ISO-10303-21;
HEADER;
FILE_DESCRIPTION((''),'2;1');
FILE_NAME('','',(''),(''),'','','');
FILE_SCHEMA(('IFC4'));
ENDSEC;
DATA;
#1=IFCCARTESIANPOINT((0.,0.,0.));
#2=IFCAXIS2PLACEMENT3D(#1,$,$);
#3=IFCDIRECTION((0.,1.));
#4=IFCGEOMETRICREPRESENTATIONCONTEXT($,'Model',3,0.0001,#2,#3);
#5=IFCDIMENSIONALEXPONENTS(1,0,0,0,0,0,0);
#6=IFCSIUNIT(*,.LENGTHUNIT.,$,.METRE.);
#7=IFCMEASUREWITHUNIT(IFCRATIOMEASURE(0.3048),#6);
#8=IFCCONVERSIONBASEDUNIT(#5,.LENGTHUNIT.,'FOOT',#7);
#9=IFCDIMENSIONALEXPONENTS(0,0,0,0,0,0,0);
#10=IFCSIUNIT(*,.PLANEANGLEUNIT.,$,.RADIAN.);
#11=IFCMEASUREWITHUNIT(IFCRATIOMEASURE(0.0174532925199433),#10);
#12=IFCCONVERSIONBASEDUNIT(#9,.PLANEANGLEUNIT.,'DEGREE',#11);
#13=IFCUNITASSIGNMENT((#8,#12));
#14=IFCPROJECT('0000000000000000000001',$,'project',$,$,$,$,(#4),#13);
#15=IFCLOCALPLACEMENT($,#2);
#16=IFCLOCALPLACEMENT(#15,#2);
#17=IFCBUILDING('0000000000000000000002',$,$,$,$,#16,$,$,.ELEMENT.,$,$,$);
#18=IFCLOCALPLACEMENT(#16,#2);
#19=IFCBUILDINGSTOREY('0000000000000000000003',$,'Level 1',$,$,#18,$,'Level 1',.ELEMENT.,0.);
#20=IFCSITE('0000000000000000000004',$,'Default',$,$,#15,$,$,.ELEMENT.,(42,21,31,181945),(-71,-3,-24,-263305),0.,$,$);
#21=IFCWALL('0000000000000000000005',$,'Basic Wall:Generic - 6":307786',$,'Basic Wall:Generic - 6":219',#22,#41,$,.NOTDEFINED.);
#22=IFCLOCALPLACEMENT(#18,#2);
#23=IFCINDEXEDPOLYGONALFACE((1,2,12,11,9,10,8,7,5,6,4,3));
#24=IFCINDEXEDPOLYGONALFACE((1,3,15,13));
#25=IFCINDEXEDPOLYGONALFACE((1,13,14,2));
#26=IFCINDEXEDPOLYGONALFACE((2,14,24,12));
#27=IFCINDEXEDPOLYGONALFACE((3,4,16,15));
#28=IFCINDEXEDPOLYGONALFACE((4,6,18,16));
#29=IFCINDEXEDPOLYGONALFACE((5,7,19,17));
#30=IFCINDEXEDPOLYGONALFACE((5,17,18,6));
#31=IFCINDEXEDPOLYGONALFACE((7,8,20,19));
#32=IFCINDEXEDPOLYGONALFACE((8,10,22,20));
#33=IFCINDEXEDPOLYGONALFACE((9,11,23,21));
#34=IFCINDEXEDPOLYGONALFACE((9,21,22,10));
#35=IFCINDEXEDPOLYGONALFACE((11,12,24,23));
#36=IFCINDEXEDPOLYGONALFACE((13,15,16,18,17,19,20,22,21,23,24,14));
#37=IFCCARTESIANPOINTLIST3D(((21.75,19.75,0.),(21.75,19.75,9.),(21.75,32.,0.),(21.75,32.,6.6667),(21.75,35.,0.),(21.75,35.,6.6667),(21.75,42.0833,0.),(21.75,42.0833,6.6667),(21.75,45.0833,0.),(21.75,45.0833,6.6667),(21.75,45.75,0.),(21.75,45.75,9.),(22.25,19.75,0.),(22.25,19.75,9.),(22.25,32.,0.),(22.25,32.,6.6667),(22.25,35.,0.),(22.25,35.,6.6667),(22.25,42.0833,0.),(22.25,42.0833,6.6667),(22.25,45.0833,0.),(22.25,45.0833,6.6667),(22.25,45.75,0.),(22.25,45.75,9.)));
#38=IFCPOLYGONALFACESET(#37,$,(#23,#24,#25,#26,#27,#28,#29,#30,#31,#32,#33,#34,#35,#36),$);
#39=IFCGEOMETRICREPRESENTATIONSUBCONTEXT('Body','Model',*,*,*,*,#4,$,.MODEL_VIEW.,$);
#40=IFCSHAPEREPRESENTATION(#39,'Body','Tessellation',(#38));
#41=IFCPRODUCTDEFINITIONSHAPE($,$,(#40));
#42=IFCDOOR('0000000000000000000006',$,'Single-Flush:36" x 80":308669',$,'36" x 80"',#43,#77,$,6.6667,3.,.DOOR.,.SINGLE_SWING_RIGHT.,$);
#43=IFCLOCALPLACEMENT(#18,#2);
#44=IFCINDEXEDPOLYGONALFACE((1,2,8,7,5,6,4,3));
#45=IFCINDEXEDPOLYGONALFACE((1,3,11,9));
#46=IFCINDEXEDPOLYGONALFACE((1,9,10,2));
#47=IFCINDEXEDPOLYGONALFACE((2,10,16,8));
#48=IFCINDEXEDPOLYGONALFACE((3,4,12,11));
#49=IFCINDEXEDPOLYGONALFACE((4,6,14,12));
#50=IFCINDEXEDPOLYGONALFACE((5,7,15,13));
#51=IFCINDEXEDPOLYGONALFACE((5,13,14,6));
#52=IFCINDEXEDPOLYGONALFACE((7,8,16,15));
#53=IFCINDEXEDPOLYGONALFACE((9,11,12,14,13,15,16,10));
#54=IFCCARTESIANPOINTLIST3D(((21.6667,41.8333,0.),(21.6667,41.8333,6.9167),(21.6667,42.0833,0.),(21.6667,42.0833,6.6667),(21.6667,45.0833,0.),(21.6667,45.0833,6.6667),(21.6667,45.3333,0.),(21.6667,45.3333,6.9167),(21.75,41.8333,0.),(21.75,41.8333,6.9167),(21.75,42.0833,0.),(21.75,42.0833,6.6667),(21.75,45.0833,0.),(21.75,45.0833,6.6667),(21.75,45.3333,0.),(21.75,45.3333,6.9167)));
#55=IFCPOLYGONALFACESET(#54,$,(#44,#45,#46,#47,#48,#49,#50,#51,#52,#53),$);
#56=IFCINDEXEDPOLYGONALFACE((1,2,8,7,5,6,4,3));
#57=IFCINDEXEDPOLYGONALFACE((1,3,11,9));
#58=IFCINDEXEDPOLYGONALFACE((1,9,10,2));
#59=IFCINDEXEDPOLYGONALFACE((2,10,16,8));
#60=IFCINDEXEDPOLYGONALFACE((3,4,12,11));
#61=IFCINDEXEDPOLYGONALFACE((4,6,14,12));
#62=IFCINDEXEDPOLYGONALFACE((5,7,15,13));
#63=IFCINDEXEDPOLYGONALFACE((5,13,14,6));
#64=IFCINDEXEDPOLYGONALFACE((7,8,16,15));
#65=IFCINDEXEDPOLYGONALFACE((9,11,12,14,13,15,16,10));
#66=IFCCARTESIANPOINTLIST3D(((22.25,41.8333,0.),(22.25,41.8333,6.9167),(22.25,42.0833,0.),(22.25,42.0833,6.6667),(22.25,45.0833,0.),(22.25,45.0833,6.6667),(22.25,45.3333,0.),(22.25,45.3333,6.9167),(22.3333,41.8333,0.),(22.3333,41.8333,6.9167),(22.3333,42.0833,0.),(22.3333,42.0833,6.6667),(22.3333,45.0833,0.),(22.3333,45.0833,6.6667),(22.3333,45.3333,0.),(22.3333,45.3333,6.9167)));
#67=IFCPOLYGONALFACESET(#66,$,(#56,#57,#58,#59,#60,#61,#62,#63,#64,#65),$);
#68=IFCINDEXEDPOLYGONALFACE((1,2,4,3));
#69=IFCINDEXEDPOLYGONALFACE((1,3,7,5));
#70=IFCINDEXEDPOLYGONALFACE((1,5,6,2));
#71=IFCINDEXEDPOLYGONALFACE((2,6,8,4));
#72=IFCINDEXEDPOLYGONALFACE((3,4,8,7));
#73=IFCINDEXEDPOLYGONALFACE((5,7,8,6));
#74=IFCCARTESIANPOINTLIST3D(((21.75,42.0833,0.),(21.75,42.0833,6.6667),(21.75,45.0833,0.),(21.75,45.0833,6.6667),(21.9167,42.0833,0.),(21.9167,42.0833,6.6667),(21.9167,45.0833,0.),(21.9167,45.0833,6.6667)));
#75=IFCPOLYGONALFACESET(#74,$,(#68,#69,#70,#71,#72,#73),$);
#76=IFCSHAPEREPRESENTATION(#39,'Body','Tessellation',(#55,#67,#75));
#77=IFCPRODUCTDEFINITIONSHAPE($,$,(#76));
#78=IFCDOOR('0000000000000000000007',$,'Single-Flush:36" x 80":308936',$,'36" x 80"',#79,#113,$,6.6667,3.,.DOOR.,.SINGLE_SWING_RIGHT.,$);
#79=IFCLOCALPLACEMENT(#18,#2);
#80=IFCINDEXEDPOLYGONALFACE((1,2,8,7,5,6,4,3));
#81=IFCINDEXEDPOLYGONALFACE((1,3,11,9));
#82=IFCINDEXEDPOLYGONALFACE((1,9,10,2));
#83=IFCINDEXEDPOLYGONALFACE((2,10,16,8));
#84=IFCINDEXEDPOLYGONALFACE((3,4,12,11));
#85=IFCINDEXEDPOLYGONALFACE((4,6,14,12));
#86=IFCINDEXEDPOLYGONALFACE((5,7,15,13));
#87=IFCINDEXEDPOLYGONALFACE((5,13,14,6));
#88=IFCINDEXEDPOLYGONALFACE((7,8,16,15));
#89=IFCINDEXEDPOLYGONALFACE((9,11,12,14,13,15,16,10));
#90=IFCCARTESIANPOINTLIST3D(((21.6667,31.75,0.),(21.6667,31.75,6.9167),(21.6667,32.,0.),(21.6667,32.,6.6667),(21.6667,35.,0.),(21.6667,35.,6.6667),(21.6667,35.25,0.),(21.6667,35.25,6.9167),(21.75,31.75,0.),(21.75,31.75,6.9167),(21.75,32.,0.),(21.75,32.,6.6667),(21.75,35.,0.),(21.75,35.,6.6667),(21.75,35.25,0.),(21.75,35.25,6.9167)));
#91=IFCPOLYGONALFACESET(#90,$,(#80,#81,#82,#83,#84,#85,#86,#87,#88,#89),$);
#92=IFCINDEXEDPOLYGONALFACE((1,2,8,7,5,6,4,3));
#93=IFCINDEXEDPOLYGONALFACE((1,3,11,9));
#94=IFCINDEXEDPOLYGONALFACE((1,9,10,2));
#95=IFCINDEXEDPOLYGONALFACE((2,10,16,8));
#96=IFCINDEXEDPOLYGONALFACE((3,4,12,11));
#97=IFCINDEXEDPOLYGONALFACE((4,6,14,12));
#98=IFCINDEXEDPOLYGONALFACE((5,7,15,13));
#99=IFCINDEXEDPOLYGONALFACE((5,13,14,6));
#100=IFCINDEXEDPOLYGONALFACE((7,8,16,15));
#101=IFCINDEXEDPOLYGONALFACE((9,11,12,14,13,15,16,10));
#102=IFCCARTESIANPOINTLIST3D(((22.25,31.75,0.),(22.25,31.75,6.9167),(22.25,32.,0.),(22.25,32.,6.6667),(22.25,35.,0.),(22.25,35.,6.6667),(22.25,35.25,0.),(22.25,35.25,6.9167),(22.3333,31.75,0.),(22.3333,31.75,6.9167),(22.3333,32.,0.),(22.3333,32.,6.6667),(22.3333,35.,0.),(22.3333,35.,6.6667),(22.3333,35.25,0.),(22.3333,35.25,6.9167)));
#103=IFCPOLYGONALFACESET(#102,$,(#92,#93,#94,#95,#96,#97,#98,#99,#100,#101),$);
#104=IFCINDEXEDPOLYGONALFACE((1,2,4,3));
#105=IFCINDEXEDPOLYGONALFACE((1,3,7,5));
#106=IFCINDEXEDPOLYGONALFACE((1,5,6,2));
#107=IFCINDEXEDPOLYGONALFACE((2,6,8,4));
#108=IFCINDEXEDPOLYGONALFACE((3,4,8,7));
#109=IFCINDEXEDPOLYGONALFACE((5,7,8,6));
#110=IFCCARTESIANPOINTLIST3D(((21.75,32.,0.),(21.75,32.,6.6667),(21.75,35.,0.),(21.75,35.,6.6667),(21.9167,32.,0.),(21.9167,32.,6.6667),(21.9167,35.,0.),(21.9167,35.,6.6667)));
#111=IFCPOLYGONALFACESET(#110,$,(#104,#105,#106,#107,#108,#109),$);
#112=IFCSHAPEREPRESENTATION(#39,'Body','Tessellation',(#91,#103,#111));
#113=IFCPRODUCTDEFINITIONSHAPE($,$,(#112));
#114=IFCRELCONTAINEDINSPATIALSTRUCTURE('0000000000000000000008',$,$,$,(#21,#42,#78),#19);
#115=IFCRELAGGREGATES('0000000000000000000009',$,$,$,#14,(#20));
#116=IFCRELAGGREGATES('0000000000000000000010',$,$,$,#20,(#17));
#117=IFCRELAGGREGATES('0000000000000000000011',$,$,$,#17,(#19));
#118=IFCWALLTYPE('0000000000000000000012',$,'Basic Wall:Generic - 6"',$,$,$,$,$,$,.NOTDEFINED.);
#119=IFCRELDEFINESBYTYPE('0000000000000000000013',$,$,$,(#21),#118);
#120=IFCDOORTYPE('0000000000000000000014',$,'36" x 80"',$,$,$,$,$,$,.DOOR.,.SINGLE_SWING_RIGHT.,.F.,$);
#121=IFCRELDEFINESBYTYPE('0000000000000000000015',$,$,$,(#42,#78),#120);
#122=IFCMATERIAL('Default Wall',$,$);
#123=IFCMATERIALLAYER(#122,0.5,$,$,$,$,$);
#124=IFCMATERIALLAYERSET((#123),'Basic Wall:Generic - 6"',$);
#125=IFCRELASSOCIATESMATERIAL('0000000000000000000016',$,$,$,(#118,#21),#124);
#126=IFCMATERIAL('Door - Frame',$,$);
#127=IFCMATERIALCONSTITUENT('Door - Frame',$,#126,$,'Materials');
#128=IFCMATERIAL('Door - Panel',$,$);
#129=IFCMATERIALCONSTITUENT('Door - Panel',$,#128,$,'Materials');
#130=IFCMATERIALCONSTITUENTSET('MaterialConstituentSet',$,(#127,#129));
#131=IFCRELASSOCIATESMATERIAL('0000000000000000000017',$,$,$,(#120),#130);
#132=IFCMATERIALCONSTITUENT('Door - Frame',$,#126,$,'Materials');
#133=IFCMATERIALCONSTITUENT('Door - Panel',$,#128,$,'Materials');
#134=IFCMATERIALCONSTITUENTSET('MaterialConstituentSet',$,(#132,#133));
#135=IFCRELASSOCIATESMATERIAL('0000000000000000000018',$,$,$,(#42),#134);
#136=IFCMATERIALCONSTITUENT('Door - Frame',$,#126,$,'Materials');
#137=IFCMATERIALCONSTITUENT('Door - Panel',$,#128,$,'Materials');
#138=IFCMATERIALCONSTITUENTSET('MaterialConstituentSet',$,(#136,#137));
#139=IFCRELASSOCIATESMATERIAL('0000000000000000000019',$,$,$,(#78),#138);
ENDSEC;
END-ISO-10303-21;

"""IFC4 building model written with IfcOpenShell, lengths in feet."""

from ifc_helpers import new_model, entity, si_unit, converted_unit, direction, frame, frame_2d, origin, origin_2d_with_axis, place, context, subcontext, project, spatial, polyline, rectangle, outline, extrude, clip, bounded_halfspace, source, transform, mapped, material, layer, layer_set, layer_usage, constituent, constituent_set, type_object, type_shapes, element, fill, save


model = new_model("IFC4")

# Units and contexts
model_context = context("Model", 3, precision=0.0001, world=origin(), true_north=direction((0.0, 1.0)))
body_context = subcontext(model_context, "Body", "Model", "MODEL_VIEW")
ifc_project = project(units=[converted_unit("LENGTHUNIT", "FOOT", entity("IfcRatioMeasure", 0.3048), si_unit("LENGTHUNIT", "METRE"), dimensions=[1, 0, 0, 0, 0, 0, 0]), converted_unit("PLANEANGLEUNIT", "DEGREE", entity("IfcRatioMeasure", 0.0174532925199433), si_unit("PLANEANGLEUNIT", "RADIAN"), dimensions=[0, 0, 0, 0, 0, 0, 0])], contexts=[model_context])

# Site, building, storey
site_placement = place(None, origin())
site = spatial("IfcSite", under=ifc_project, at=site_placement, Name="Default", CompositionType="ELEMENT", RefLatitude=(42, 21, 31, 181945), RefLongitude=(-71, -3, -24, -263305), RefElevation=0.0)
building_placement = place(site_placement, origin())
building = spatial("IfcBuilding", under=site, at=building_placement, CompositionType="ELEMENT")
storey_placement = place(building_placement, origin())
storey = spatial("IfcBuildingStorey", under=building, at=storey_placement, Name="Level 1", LongName="Level 1", CompositionType="ELEMENT", Elevation=0.0)

# Shared definitions
wall_placement = place(storey_placement, frame((22.0, 45.75, 0.0), z_axis=(0.0, 0.0, 1.0), x_axis=(0.0, -1.0, 0.0)))

# Wall, openings, doors
ifc_material_1 = material(Name="Default Wall")
ifc_layer = layer(ifc_material_1, 0.5)
ifc_layer_set = layer_set([ifc_layer], Name="Basic Wall:Generic - 6\"")
ifc_layer_usage = layer_usage(ifc_layer_set, "AXIS2", "NEGATIVE", 0.25)
wall_type = type_object("IfcWallType", Name="Basic Wall:Generic - 6\"", PredefinedType="NOTDEFINED", material=ifc_layer_set)
wall = element("IfcWall", 1, at=wall_placement, inside=storey, type_object=wall_type, material=ifc_layer_usage, Name="Basic Wall:Generic - 6\":307786", ObjectType="Basic Wall:Generic - 6\":219", PredefinedType="NOTDEFINED", context=body_context, shape_type="Clipping", body=[
    clip(clip(clip(extrude(rectangle(XDim=26.0, YDim=0.5, at=frame_2d((13.0, 0.0), x_axis=(-1.0, 0.0))), origin(), (0.0, 0.0, 1.0), 9.0), bounded_halfspace(frame((10.0, -0.25, 9.0), z_axis=(0.0, 0.0, -1.0), x_axis=(0.0, -1.0, 0.0)), True, frame((10.0, -0.25, 9.0)), polyline([(0.0, 0.0), (0.0, 0.5), (-10.0, 0.5), (-10.0, 0.0), (-0.5, 0.0), (0.0, 0.0)]))), bounded_halfspace(frame((10.0, -0.25, 9.0), z_axis=(0.0, 0.0, -1.0), x_axis=(-1.0, 0.0, 0.0)), True, frame((10.0, -0.25, 9.0)), polyline([(0.0, 0.0), (15.5, 0.0), (15.5, 0.5), (0.0, 0.5), (0.0, 0.0)]))), bounded_halfspace(frame((25.5, -0.25, 9.0), z_axis=(0.0, 0.0, -1.0), x_axis=(1.0, 0.0, 0.0)), True, frame((25.5, -0.25, 9.0)), polyline([(0.0, 0.0), (0.5, 0.0), (0.5, 0.5), (0.0, 0.5), (0.0, 0.0)]))),
])
opening_1_placement = place(wall_placement, frame((3.6667, 0.25, 0.0)))
opening_1 = element("IfcOpeningElement", 2, at=opening_1_placement, cuts=wall, ObjectType="Opening", PredefinedType="OPENING", context=body_context, shape_type="SweptSolid", body=[
    extrude(rectangle(XDim=3.0, YDim=6.6667, at=frame_2d((3.3333, 1.5), x_axis=(0.0, 1.0))), frame((0.0, 0.0, 0.0), z_axis=(0.0, -1.0, 0.0), x_axis=(0.0, 0.0, 1.0)), (0.0, 0.0, 1.0), 0.5),
])
opening_2_placement = place(wall_placement, frame((13.75, 0.25, 0.0)))
opening_2 = element("IfcOpeningElement", 3, at=opening_2_placement, cuts=wall, ObjectType="Opening", PredefinedType="OPENING", context=body_context, shape_type="SweptSolid", body=[
    extrude(rectangle(XDim=3.0, YDim=6.6667, at=frame_2d((3.3333, 1.5), x_axis=(0.0, 1.0))), frame((0.0, 0.0, 0.0), z_axis=(0.0, -1.0, 0.0), x_axis=(0.0, 0.0, 1.0)), (0.0, 0.0, 1.0), 0.5),
])
ifc_material_2 = material(Name="Door - Frame")
ifc_constituent_1 = constituent(ifc_material_2, Name="Door - Frame", Category="Materials")
ifc_material_3 = material(Name="Door - Panel")
ifc_constituent_2 = constituent(ifc_material_3, Name="Door - Panel", Category="Materials")
ifc_constituent_set_1 = constituent_set(constituents=[ifc_constituent_1, ifc_constituent_2], Name="MaterialConstituentSet")
ifc_constituent_3 = constituent(ifc_material_2, Name="Door - Frame", Category="Materials")
ifc_constituent_4 = constituent(ifc_material_3, Name="Door - Panel", Category="Materials")
ifc_constituent_set_2 = constituent_set(constituents=[ifc_constituent_3, ifc_constituent_4], Name="MaterialConstituentSet")
door_type = type_object("IfcDoorType", Name="36\" x 80\"", OperationType="SINGLE_SWING_RIGHT", ParameterTakesPrecedence=False, PredefinedType="DOOR", material=ifc_constituent_set_2)
shared_shape = source(origin(), body_context, "Body", "SweptSolid", [
    extrude(outline(polyline([(-1.75, -3.5208), (1.75, -3.5208), (1.75, 3.3958), (1.5, 3.3958), (1.5, -3.2708), (-1.5, -3.2708), (-1.5, 3.3958), (-1.75, 3.3958), (-1.75, -3.5208)])), frame((1.5, 0.5, 3.3958), z_axis=(0.0, 1.0, 0.0), x_axis=(1.0, 0.0, 0.0)), (0.0, 0.0, 1.0), 0.0833),
    extrude(outline(polyline([(-3.5208, -1.75), (3.3958, -1.75), (3.3958, -1.5), (-3.2708, -1.5), (-3.2708, 1.5), (3.3958, 1.5), (3.3958, 1.75), (-3.5208, 1.75), (-3.5208, -1.75)])), frame((1.5, -0.0833, 3.3958), z_axis=(0.0, 1.0, 0.0), x_axis=(0.0, 0.0, -1.0)), (0.0, 0.0, 1.0), 0.0833),
    extrude(rectangle(XDim=0.1667, YDim=3.0, at=origin_2d_with_axis()), frame((1.5, 0.4167, 0.0), z_axis=(0.0, 0.0, 1.0), x_axis=(0.0, 1.0, 0.0)), (0.0, 0.0, 1.0), 6.6667),
])
type_shapes(door_type, [shared_shape])
door_1_placement = place(opening_1_placement, frame((0.0, 0.0, 0.0), z_axis=(0.0, 0.0, 1.0), x_axis=(-1.0, 0.0, 0.0)))
door_1 = element("IfcDoor", 4, at=door_1_placement, inside=storey, type_object=door_type, material=ifc_constituent_set_1, Name="Single-Flush:36\" x 80\":308669", ObjectType="36\" x 80\"", OperationType="SINGLE_SWING_RIGHT", OverallHeight=6.6667, OverallWidth=3.0, PredefinedType="DOOR", context=body_context, shape_type="MappedRepresentation", body=[
    mapped(shared_shape, transform((0.0, 0.0, 0.0), scale=1.0)),
])
fill(opening_1, door_1)
ifc_constituent_5 = constituent(ifc_material_2, Name="Door - Frame", Category="Materials")
ifc_constituent_6 = constituent(ifc_material_3, Name="Door - Panel", Category="Materials")
ifc_constituent_set_3 = constituent_set(constituents=[ifc_constituent_5, ifc_constituent_6], Name="MaterialConstituentSet")
door_2_placement = place(opening_2_placement, frame((0.0, 0.0, 0.0), z_axis=(0.0, 0.0, 1.0), x_axis=(-1.0, 0.0, 0.0)))
door_2 = element("IfcDoor", 5, at=door_2_placement, inside=storey, type_object=door_type, material=ifc_constituent_set_3, Name="Single-Flush:36\" x 80\":308936", ObjectType="36\" x 80\"", OperationType="SINGLE_SWING_RIGHT", OverallHeight=6.6667, OverallWidth=3.0, PredefinedType="DOOR", context=body_context, shape_type="MappedRepresentation", body=[
    mapped(shared_shape, transform((0.0, 0.0, 0.0), scale=1.0)),
])
fill(opening_2, door_2)

save(model, "model.ifc")
